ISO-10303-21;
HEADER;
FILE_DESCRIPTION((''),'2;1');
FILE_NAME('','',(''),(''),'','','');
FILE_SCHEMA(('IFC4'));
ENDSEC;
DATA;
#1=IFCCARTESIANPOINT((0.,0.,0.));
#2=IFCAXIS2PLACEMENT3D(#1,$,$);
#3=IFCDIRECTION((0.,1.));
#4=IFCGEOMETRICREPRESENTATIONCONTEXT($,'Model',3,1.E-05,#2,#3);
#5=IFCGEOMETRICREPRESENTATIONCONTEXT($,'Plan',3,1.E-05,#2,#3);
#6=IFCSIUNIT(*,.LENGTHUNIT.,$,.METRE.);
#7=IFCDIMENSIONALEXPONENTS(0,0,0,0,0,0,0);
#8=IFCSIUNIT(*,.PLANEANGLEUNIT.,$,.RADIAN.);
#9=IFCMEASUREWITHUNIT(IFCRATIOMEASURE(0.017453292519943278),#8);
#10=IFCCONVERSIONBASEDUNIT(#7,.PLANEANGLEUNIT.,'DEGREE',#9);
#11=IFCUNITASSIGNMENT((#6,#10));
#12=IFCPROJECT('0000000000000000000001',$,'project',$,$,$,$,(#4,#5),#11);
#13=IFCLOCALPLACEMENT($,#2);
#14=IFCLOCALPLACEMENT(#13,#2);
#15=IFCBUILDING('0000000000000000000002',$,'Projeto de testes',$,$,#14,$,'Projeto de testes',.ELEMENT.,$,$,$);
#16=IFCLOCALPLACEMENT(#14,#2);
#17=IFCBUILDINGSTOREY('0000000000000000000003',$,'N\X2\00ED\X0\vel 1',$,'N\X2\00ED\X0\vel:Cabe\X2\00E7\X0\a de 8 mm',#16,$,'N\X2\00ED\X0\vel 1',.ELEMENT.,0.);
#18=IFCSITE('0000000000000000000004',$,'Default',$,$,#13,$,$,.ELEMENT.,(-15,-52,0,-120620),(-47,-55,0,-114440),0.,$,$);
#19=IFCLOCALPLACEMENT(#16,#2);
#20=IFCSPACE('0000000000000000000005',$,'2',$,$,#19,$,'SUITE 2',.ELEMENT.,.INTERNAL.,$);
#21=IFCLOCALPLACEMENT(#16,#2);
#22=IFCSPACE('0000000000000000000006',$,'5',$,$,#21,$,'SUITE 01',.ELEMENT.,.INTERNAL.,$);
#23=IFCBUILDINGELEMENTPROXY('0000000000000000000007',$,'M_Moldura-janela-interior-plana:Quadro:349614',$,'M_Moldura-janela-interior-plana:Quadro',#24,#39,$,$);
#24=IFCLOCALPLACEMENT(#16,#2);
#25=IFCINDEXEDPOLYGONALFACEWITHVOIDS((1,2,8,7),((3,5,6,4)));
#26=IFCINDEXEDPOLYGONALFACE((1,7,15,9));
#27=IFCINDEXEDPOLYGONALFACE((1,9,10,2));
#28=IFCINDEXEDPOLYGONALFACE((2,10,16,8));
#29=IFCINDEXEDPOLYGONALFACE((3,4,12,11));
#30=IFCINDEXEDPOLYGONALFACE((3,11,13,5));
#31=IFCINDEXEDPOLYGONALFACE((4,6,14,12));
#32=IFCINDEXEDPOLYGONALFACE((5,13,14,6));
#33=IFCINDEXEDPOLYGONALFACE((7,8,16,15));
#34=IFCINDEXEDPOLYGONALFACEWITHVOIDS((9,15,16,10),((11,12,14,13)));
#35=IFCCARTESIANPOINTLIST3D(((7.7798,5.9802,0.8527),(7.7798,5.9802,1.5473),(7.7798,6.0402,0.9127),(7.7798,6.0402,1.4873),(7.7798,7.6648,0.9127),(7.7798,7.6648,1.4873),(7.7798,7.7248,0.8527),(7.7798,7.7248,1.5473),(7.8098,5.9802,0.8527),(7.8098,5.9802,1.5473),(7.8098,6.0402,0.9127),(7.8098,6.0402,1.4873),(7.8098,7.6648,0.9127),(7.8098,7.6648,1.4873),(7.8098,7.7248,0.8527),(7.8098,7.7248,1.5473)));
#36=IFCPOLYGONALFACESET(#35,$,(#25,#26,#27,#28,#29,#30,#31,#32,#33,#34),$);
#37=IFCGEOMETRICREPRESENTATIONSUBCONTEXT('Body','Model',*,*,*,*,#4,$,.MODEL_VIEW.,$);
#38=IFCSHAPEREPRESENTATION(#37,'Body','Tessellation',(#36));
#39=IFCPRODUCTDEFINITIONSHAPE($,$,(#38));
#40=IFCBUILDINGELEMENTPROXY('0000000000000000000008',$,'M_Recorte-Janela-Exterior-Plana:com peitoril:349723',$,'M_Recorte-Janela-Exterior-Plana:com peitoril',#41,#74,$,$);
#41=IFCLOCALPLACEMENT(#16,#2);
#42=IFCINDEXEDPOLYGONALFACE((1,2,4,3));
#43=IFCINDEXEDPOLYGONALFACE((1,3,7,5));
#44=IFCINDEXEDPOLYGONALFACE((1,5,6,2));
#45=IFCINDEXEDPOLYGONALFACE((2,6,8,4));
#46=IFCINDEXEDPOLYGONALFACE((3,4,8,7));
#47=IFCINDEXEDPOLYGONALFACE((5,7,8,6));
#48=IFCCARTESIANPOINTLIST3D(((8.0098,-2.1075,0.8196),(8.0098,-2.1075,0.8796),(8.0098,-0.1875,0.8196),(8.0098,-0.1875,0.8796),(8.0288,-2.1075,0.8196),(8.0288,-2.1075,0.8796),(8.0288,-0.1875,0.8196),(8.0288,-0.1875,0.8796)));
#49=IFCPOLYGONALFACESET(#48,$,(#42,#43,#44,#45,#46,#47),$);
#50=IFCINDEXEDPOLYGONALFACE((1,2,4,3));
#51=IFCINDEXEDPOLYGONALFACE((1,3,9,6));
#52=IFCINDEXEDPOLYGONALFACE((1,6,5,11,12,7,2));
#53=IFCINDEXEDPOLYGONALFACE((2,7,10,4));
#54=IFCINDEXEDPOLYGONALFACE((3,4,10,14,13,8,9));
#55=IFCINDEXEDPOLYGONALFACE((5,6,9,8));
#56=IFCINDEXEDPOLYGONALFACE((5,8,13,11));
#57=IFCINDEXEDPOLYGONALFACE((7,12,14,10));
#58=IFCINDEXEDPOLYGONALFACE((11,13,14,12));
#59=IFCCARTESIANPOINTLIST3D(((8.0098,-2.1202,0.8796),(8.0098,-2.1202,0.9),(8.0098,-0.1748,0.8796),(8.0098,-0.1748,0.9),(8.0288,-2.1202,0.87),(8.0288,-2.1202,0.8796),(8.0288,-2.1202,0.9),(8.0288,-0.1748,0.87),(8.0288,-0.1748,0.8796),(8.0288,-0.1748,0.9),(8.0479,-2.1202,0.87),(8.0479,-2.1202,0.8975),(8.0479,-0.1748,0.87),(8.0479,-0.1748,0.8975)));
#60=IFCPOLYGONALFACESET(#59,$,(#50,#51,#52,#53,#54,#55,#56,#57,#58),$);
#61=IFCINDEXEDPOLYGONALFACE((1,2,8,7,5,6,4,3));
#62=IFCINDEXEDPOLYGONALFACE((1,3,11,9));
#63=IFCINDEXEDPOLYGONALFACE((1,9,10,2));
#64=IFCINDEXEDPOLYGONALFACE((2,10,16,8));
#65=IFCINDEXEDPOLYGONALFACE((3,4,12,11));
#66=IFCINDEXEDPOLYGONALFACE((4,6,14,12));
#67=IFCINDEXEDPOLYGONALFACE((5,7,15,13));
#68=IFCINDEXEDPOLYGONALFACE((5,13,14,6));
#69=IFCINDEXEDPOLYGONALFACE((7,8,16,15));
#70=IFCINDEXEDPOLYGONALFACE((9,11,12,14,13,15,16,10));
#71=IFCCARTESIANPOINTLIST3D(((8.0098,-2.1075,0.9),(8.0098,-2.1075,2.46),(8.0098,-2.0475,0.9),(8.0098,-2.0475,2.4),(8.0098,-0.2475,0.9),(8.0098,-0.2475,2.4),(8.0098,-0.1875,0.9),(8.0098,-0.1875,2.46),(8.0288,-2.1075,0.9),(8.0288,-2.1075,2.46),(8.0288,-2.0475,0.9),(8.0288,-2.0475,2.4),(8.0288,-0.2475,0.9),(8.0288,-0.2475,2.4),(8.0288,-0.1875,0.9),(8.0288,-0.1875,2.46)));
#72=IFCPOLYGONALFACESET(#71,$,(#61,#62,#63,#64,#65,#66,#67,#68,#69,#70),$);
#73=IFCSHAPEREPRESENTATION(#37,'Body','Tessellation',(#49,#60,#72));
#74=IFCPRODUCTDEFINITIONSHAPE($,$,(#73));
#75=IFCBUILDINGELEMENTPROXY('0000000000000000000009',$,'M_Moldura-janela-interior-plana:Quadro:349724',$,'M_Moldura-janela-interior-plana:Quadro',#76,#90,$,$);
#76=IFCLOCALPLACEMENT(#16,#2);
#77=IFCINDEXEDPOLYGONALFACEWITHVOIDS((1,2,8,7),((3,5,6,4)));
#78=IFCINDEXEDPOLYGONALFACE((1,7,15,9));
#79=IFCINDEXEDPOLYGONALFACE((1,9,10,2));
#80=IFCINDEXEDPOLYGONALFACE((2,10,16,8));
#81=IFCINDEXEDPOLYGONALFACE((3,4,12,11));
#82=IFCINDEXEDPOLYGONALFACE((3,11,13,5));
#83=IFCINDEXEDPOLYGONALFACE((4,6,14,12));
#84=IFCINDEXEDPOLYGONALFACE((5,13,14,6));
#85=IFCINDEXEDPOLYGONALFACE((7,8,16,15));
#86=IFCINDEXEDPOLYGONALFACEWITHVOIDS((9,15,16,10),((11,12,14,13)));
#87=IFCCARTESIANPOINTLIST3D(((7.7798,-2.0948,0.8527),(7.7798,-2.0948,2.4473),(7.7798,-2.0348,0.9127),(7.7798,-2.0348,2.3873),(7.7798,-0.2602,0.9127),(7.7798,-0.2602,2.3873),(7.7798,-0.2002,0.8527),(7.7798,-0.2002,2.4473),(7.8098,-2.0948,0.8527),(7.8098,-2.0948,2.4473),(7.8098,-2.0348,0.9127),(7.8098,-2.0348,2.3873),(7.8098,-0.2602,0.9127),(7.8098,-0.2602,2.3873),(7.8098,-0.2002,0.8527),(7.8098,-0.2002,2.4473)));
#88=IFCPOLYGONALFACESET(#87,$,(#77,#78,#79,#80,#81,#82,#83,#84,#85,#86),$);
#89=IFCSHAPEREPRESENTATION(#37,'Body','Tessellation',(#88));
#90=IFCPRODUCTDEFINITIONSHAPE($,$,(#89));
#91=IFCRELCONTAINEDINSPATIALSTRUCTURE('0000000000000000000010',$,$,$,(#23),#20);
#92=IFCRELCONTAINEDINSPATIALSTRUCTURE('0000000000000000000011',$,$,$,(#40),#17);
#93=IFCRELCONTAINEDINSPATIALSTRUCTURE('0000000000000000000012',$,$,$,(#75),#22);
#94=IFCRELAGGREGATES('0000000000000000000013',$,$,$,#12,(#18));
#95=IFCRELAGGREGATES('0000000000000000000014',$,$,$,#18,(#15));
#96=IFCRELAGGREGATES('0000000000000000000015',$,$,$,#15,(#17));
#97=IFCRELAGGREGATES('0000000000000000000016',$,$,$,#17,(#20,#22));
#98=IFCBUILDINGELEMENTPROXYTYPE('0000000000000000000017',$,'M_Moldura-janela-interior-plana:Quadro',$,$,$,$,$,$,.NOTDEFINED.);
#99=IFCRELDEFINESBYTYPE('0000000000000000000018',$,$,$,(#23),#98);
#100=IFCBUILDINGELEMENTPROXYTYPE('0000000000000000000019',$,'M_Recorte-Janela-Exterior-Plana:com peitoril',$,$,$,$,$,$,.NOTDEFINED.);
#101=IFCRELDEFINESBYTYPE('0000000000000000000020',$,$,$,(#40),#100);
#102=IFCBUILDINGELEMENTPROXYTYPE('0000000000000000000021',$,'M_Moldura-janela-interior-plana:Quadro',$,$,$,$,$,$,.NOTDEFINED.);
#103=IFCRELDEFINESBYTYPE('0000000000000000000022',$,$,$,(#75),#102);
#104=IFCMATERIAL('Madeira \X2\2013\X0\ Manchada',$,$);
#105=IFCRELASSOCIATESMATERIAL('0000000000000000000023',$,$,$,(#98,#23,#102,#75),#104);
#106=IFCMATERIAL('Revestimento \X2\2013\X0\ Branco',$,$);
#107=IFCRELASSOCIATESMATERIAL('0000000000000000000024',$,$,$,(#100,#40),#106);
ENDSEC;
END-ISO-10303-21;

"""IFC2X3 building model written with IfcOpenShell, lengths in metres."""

from ifc_helpers import new_model, entity, si_unit, converted_unit, direction, frame, frame_2d, origin, place, context, subcontext, project, spatial, polyline, rectangle, outline, extrude, source, transform, mapped, material, type_object, type_shapes, element, save


model = new_model("IFC2X3")

# Units and contexts
model_context = context("Model", 3, precision=1e-05, world=origin(), true_north=direction((0.0, 1.0)))
plan_context = context("Plan", 3, precision=1e-05, world=origin(), true_north=direction((0.0, 1.0)))
body_context = subcontext(model_context, "Body", "Model", "MODEL_VIEW")
ifc_project = project(units=[si_unit("LENGTHUNIT", "METRE"), converted_unit("PLANEANGLEUNIT", "DEGREE", entity("IfcRatioMeasure", 0.017453292519943278), si_unit("PLANEANGLEUNIT", "RADIAN"), dimensions=[0, 0, 0, 0, 0, 0, 0])], contexts=[model_context, plan_context])

# Site, building, storey
site_placement = place(None, origin())
site = spatial("IfcSite", under=ifc_project, at=site_placement, Name="Default", CompositionType="ELEMENT", RefLatitude=(-15, -52, 0, -120620), RefLongitude=(-47, -55, 0, -114440), RefElevation=0.0)
building_placement = place(site_placement, origin())
building = spatial("IfcBuilding", under=site, at=building_placement, Name="Projeto de testes", LongName="Projeto de testes", CompositionType="ELEMENT")
storey_placement = place(building_placement, origin())
storey = spatial("IfcBuildingStorey", under=building, at=storey_placement, Name="Nível 1", ObjectType="Nível:Cabeça de 8 mm", LongName="Nível 1", CompositionType="ELEMENT", Elevation=0.0)

# Shared definitions
ifc_material_1 = material(Name="Revestimento – Branco")

# Shared definitions
space_1_placement = place(storey_placement, origin())
space_1 = spatial("IfcSpace", under=storey, at=space_1_placement, Name="2", LongName="SUITE 2", CompositionType="ELEMENT", InteriorOrExteriorSpace="INTERNAL")

# Building element proxies
ifc_material_2 = material(Name="Madeira – Manchada")
building_element_proxy_type_1 = type_object("IfcBuildingElementProxyType", Name="M_Moldura-janela-interior-plana:Quadro", PredefinedType="NOTDEFINED", material=ifc_material_2)
shared_shape_1 = source(origin(), body_context, "Body", "SweptSolid", [
    extrude(outline(polyline([(-0.8723, -0.3473), (0.8723, -0.3473), (0.8723, 0.3473), (-0.8723, 0.3473), (-0.8723, -0.3473)]), holes=[polyline([(-0.8123, -0.2873), (-0.8123, 0.2873), (0.8123, 0.2873), (0.8123, -0.2873), (-0.8123, -0.2873)])]), frame((0.0, -0.3, 0.0), z_axis=(0.0, 0.0, 1.0), x_axis=(-1.0, 0.0, 0.0)), (0.0, 0.0, 1.0), 0.03),
])
type_shapes(building_element_proxy_type_1, [shared_shape_1])
proxy_1_placement = place(space_1_placement, frame((7.8098, 6.8525, 1.5), z_axis=(-1.0, 0.0, 0.0), x_axis=(0.0, -1.0, 0.0)))
element("IfcBuildingElementProxy", 1, at=proxy_1_placement, inside=space_1, type_object=building_element_proxy_type_1, material=ifc_material_2, Name="M_Moldura-janela-interior-plana:Quadro:349614", ObjectType="M_Moldura-janela-interior-plana:Quadro", context=body_context, shape_type="MappedRepresentation", body=[
    mapped(shared_shape_1, transform((0.0, 0.0, 0.0), scale=1.0)),
])
building_element_proxy_type_2 = type_object("IfcBuildingElementProxyType", Name="M_Recorte-Janela-Exterior-Plana:com peitoril", PredefinedType="NOTDEFINED", material=ifc_material_1)
shared_shape_2 = source(origin(), body_context, "Body", "SweptSolid", [
    extrude(rectangle(XDim=1.92, YDim=0.06, at=frame_2d((0.0, 0.0), x_axis=(1.0, 0.0))), frame((0.0, -1.5504, 0.0), z_axis=(0.0, 0.0, 1.0), x_axis=(-1.0, 0.0, 0.0)), (0.0, 0.0, 1.0), 0.019),
    extrude(outline(polyline([(-0.019, -0.0152), (0.0, -0.0152), (0.0, -0.0057), (0.019, -0.0057), (0.019, 0.0148), (0.0, 0.0148), (-0.019, 0.0123), (-0.019, -0.0152)])), frame((-0.9727, -1.5148, 0.019), z_axis=(1.0, 0.0, 0.0), x_axis=(0.0, 0.0, -1.0)), (0.0, 0.0, 1.0), 1.9454),
    extrude(outline(polyline([(-0.795, -0.96), (0.765, -0.96), (0.765, -0.9), (-0.735, -0.9), (-0.735, 0.9), (0.765, 0.9), (0.765, 0.96), (-0.795, 0.96), (-0.795, -0.96)])), frame((0.0, -0.735, 0.0), z_axis=(0.0, 0.0, 1.0), x_axis=(0.0, -1.0, 0.0)), (0.0, 0.0, 1.0), 0.019),
])
type_shapes(building_element_proxy_type_2, [shared_shape_2])
proxy_2_placement = place(storey_placement, frame((8.0098, -1.1475, 2.4), z_axis=(1.0, 0.0, 0.0), x_axis=(0.0, 1.0, 0.0)))
element("IfcBuildingElementProxy", 2, at=proxy_2_placement, inside=storey, type_object=building_element_proxy_type_2, material=ifc_material_1, Name="M_Recorte-Janela-Exterior-Plana:com peitoril:349723", ObjectType="M_Recorte-Janela-Exterior-Plana:com peitoril", context=body_context, shape_type="MappedRepresentation", body=[
    mapped(shared_shape_2, transform((0.0, 0.0, 0.0), scale=1.0)),
])

# Shared definitions
space_2_placement = place(storey_placement, origin())
space_2 = spatial("IfcSpace", under=storey, at=space_2_placement, Name="5", LongName="SUITE 01", CompositionType="ELEMENT", InteriorOrExteriorSpace="INTERNAL")

# Building element proxy
building_element_proxy_type_3 = type_object("IfcBuildingElementProxyType", Name="M_Moldura-janela-interior-plana:Quadro", PredefinedType="NOTDEFINED", material=ifc_material_2)
shared_shape_3 = source(origin(), body_context, "Body", "SweptSolid", [
    extrude(outline(polyline([(-0.9473, -0.7973), (0.9473, -0.7973), (0.9473, 0.7973), (-0.9473, 0.7973), (-0.9473, -0.7973)]), holes=[polyline([(-0.8873, -0.7373), (-0.8873, 0.7373), (0.8873, 0.7373), (0.8873, -0.7373), (-0.8873, -0.7373)])]), frame((0.0, -0.75, 0.0), z_axis=(0.0, 0.0, 1.0), x_axis=(-1.0, 0.0, 0.0)), (0.0, 0.0, 1.0), 0.03),
])
type_shapes(building_element_proxy_type_3, [shared_shape_3])
proxy_3_placement = place(space_2_placement, frame((7.8098, -1.1475, 2.4), z_axis=(-1.0, 0.0, 0.0), x_axis=(0.0, -1.0, 0.0)))
element("IfcBuildingElementProxy", 3, at=proxy_3_placement, inside=space_2, type_object=building_element_proxy_type_3, material=ifc_material_2, Name="M_Moldura-janela-interior-plana:Quadro:349724", ObjectType="M_Moldura-janela-interior-plana:Quadro", context=body_context, shape_type="MappedRepresentation", body=[
    mapped(shared_shape_3, transform((0.0, 0.0, 0.0), scale=1.0)),
])

save(model, "model.ifc")
